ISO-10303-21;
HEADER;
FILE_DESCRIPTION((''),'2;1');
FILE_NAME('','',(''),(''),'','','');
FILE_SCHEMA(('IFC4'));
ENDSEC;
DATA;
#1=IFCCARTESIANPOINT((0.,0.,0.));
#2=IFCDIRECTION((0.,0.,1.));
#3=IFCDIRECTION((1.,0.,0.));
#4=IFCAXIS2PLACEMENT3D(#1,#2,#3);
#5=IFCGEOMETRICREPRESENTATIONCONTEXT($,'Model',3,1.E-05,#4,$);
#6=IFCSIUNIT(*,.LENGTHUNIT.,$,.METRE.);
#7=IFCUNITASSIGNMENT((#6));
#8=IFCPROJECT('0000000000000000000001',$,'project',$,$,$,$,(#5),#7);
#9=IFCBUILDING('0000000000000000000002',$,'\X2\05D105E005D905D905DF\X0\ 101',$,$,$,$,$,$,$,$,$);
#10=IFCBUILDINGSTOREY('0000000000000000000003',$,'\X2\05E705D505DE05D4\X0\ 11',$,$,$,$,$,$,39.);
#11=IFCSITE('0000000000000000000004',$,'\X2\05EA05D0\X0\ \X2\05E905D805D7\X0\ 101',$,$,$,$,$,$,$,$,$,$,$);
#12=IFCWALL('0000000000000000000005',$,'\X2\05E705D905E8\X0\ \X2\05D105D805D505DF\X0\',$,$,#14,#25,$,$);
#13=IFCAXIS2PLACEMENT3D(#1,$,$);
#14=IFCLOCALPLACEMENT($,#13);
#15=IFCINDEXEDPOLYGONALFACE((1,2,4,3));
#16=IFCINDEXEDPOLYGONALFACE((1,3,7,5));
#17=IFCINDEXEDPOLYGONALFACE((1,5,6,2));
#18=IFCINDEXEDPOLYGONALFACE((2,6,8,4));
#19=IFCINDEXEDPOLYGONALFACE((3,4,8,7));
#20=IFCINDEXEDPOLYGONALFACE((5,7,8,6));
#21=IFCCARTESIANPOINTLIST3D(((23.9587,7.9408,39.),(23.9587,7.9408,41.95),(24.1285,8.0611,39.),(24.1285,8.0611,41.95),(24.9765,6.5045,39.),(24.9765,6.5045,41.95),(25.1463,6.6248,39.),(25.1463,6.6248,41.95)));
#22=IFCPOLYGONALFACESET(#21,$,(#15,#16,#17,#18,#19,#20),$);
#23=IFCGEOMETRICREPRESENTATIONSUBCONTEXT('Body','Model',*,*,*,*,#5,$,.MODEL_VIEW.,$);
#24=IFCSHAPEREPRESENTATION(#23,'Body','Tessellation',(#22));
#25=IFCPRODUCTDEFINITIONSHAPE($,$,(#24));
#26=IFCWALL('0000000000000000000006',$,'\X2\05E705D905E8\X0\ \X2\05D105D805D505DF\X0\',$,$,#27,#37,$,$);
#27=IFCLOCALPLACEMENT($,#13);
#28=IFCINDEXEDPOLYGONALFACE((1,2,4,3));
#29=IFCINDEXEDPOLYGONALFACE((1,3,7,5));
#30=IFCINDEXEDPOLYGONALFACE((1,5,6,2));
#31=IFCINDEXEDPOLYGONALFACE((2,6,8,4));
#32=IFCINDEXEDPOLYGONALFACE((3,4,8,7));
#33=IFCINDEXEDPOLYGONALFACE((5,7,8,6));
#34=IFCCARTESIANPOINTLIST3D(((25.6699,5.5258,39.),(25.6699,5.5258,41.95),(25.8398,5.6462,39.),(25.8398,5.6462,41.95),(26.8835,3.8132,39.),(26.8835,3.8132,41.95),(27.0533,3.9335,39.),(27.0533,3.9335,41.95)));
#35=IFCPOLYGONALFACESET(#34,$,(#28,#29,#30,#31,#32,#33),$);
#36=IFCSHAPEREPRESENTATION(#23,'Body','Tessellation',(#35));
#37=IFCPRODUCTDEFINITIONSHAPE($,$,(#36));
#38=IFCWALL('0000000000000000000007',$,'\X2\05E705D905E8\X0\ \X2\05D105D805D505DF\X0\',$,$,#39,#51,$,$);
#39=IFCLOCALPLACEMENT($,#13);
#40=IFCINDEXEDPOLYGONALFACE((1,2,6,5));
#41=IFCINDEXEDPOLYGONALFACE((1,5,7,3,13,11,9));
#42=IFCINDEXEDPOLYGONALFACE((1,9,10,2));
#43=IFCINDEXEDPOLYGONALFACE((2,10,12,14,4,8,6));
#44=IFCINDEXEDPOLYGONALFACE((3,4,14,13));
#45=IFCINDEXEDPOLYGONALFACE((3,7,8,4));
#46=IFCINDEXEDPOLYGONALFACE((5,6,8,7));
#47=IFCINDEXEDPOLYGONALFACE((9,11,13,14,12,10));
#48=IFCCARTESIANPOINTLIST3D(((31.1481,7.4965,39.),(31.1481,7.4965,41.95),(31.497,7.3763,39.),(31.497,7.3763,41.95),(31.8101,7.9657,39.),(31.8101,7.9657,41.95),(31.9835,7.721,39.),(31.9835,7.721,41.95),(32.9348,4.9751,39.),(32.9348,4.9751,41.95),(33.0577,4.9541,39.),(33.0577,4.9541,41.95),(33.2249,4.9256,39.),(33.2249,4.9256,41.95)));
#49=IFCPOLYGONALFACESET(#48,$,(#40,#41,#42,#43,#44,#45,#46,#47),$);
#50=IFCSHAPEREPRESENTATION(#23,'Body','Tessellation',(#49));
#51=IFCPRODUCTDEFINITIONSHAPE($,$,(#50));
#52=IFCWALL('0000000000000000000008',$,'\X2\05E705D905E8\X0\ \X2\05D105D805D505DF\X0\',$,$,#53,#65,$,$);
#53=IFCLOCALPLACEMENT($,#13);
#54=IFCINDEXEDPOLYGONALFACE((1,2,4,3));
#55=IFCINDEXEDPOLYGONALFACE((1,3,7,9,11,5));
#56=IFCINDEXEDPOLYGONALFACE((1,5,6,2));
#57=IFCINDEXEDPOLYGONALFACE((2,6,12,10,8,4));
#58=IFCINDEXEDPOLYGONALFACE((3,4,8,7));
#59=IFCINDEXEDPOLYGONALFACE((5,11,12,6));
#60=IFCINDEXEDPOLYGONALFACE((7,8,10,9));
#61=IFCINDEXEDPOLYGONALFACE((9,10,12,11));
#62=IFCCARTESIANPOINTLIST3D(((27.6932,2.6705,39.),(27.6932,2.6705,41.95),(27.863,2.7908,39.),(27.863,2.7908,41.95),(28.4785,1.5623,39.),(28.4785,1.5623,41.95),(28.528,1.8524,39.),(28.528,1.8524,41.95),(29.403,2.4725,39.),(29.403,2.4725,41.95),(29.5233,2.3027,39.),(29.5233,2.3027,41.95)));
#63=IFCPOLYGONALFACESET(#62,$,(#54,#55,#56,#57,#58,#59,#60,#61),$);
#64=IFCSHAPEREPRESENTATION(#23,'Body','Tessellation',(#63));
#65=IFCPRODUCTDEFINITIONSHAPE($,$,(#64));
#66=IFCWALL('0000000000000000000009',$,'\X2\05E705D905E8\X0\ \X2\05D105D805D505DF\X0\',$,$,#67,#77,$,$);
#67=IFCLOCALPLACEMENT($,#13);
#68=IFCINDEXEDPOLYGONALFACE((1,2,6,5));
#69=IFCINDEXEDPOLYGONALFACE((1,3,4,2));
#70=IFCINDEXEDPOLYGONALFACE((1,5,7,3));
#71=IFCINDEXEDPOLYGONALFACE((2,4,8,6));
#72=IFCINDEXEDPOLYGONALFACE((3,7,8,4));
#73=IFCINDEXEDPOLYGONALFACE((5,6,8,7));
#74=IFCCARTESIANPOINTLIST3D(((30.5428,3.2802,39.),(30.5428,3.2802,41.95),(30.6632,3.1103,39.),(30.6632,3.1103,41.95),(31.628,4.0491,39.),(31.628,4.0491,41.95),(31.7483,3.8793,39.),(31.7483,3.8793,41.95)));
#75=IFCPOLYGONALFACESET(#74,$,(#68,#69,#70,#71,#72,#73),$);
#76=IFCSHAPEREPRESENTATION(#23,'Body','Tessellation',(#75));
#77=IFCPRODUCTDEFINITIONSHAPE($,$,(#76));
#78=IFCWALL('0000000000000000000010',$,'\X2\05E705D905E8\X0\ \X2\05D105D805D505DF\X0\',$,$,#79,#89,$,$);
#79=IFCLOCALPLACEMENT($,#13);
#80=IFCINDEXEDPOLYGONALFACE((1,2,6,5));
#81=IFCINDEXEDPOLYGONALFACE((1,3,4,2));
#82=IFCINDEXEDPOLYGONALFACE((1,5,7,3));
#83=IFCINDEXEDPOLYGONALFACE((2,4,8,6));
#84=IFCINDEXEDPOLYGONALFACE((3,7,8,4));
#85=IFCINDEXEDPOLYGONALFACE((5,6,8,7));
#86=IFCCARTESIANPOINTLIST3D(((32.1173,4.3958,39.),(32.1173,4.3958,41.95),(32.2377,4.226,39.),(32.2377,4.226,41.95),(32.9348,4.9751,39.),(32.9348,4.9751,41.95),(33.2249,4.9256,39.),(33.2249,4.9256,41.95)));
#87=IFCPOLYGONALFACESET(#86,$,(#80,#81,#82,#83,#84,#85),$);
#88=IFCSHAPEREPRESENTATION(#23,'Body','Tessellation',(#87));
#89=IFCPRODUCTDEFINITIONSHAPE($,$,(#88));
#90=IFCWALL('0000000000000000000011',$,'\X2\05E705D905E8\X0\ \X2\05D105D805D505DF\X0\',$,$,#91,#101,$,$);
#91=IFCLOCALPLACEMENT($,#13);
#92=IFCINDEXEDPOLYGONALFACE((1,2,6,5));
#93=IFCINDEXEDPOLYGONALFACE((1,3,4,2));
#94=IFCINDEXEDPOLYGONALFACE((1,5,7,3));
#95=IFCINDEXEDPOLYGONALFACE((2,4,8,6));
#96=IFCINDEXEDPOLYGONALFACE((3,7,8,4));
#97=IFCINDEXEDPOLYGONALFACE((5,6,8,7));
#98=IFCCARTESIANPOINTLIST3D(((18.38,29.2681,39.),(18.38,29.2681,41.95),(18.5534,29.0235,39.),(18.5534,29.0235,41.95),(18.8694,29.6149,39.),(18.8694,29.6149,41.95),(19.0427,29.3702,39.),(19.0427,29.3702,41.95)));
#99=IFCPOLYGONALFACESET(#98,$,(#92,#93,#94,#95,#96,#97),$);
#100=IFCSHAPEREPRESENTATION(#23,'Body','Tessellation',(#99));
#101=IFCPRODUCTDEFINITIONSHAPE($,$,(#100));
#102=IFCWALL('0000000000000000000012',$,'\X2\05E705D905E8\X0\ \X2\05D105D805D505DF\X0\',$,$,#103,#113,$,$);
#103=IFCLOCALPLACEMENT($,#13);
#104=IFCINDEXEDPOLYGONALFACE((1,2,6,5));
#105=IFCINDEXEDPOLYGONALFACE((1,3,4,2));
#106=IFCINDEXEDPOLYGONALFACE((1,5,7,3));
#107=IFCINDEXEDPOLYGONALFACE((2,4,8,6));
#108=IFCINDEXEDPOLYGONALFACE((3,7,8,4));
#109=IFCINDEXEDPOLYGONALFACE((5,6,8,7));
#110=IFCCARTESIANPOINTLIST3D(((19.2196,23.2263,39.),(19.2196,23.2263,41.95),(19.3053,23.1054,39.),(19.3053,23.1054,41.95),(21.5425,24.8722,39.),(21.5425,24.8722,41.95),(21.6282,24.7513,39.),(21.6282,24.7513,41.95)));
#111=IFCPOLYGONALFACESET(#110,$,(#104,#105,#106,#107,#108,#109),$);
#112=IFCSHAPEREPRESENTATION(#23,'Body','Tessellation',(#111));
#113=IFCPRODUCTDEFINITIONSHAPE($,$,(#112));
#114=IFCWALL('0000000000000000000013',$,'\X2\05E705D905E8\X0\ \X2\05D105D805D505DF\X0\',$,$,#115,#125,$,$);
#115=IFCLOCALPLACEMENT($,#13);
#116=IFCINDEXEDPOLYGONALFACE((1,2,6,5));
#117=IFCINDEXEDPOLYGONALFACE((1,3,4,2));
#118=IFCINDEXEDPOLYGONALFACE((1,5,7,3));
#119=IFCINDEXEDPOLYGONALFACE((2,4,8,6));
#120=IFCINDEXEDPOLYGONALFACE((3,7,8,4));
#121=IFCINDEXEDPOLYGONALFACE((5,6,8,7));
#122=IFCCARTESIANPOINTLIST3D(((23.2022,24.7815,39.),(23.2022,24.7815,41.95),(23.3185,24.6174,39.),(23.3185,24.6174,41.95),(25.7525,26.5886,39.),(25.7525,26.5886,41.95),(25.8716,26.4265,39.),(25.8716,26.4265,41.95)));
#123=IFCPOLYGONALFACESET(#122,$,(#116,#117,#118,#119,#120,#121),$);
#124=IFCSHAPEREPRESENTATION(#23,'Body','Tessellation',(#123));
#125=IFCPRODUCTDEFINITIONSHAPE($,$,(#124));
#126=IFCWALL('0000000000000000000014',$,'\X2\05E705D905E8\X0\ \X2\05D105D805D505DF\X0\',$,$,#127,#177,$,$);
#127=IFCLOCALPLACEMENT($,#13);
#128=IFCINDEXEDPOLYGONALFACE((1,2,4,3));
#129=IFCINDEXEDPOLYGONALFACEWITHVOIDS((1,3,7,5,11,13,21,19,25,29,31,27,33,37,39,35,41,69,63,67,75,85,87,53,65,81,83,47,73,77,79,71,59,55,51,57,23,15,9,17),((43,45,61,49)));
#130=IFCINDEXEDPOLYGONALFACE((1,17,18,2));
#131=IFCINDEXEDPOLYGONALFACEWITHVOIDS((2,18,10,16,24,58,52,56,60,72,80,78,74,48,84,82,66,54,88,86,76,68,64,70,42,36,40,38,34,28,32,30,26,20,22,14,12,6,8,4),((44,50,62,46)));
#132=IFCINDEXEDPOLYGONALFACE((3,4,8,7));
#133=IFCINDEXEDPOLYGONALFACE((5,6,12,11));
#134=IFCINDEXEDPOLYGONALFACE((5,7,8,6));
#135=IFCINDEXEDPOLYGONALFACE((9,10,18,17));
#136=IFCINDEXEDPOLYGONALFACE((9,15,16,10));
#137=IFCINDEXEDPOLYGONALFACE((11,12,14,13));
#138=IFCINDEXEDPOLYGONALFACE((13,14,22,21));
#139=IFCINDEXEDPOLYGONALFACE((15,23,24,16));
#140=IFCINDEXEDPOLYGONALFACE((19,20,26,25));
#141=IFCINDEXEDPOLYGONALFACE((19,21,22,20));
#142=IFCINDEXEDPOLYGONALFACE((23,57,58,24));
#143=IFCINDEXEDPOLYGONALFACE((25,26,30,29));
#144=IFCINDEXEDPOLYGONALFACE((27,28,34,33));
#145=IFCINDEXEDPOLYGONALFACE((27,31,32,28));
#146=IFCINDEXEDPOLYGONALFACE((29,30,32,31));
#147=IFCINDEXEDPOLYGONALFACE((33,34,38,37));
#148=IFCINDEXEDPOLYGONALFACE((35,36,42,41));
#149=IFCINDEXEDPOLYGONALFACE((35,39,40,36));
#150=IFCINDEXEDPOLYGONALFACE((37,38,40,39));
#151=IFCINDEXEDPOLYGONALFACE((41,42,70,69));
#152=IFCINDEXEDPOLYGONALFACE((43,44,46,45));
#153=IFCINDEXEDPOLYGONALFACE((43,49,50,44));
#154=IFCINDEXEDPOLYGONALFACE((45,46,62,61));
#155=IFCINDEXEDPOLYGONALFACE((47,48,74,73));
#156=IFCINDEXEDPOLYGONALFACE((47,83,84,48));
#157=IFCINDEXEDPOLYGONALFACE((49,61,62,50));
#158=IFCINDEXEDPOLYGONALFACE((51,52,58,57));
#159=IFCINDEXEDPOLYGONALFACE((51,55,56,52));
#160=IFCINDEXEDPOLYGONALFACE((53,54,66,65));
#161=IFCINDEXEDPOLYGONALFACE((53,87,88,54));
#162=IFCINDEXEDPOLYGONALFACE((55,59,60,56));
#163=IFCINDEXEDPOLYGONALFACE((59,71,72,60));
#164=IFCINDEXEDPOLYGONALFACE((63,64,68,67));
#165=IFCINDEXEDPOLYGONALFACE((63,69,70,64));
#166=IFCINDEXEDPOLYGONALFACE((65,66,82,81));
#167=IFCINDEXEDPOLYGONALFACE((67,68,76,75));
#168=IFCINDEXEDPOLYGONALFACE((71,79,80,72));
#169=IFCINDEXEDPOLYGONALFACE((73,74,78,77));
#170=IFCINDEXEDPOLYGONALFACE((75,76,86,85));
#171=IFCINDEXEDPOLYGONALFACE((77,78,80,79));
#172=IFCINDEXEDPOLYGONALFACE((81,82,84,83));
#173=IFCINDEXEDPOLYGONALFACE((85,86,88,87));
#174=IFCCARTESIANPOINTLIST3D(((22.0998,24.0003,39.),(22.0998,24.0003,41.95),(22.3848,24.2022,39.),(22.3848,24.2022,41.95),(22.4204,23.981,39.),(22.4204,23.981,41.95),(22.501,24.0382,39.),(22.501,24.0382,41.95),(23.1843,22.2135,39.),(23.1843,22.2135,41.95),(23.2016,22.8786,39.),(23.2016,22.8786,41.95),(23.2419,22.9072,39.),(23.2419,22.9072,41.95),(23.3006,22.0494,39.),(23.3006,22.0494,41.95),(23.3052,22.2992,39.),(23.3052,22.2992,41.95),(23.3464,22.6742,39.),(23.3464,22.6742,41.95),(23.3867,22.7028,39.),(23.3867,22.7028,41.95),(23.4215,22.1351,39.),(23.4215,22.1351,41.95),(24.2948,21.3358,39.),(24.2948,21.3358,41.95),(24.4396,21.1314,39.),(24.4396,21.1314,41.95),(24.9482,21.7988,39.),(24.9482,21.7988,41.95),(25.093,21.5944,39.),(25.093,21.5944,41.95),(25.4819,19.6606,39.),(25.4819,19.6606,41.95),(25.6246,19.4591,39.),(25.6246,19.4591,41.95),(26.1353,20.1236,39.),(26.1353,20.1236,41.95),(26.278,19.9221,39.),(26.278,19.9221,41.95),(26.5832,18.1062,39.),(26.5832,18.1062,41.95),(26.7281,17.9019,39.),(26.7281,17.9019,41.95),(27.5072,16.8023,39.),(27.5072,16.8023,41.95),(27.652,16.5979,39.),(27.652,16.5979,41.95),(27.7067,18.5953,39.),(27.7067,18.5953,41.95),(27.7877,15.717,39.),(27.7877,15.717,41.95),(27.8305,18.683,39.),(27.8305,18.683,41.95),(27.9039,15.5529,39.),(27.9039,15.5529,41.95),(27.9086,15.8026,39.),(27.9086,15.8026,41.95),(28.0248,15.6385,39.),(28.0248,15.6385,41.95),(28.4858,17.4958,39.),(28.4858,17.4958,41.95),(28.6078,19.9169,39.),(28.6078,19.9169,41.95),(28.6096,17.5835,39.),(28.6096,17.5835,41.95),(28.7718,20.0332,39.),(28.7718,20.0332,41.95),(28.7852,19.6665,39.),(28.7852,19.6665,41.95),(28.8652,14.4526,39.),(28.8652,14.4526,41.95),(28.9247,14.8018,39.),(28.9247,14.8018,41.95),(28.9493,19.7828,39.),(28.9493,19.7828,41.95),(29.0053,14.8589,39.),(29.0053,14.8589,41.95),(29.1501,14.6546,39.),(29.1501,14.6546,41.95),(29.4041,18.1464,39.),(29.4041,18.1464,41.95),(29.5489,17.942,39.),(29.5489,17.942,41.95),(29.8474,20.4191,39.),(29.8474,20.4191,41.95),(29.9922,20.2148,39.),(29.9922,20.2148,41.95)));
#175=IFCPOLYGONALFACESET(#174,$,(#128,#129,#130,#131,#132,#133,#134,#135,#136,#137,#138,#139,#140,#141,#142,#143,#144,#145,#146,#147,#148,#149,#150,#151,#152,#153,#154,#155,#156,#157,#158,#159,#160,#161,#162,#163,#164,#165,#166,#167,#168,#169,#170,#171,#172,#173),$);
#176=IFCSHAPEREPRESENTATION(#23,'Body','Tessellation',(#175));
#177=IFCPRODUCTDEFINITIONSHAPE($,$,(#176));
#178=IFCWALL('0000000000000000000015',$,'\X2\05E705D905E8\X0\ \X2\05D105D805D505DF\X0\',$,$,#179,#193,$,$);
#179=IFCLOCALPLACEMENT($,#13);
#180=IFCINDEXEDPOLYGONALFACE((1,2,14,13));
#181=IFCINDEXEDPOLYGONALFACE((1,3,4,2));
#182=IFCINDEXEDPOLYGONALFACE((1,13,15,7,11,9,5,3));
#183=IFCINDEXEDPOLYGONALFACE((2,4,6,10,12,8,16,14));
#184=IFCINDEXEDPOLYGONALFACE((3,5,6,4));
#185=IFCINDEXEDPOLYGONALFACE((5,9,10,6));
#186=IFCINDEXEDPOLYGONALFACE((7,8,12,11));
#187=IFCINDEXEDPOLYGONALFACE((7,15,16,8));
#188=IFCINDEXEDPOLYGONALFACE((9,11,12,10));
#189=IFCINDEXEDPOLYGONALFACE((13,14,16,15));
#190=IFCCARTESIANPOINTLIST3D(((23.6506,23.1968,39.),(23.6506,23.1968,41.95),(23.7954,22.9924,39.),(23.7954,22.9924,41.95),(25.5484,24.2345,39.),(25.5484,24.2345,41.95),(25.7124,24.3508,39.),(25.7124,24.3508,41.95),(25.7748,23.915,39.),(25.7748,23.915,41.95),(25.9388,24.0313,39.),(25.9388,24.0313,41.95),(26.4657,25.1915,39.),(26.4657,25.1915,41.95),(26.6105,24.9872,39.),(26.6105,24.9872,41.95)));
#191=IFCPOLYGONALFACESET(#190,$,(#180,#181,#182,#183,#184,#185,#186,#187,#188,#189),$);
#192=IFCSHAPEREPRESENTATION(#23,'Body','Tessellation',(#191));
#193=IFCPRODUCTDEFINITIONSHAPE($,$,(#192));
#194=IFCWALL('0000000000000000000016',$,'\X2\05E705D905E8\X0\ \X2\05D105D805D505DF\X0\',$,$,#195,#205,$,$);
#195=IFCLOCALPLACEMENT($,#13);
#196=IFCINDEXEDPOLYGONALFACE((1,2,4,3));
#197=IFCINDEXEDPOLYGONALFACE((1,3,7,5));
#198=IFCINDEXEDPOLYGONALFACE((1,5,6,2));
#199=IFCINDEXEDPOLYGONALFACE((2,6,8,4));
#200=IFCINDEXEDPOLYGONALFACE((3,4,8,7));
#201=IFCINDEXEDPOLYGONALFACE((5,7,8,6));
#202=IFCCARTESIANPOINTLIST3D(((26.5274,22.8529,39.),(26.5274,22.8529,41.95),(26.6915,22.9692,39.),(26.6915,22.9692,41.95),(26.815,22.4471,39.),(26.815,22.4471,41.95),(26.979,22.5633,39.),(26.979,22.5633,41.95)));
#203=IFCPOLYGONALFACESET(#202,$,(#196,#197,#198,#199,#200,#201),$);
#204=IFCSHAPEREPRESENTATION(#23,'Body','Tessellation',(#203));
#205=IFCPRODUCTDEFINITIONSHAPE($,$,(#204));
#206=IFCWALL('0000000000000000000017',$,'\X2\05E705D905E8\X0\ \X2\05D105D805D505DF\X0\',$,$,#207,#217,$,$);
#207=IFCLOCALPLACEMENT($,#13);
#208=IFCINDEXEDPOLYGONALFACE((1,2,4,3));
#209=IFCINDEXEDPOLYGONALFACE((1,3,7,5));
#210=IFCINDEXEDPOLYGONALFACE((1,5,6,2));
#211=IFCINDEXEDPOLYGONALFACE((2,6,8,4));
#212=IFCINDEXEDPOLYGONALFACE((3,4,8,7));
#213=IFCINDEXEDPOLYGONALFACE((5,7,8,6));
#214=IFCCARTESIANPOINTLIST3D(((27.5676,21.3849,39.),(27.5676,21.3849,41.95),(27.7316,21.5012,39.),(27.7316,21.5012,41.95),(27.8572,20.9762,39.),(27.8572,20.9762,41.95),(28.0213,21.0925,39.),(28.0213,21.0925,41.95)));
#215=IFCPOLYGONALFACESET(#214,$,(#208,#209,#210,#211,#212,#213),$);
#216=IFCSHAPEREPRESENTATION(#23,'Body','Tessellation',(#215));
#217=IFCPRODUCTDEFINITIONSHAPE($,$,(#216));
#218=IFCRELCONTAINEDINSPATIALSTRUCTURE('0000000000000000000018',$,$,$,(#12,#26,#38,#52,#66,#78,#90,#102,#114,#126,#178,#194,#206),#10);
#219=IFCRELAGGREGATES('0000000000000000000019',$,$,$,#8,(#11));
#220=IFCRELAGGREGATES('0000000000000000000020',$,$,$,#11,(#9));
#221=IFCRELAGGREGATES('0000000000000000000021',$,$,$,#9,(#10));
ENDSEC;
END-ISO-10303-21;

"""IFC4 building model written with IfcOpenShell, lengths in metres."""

from ifc_helpers import new_model, si_unit, frame, origin_with_axes, context, subcontext, project, spatial, polyline, outline, extrude, element, save


model = new_model("IFC4")

# Units and contexts
model_context = context("Model", 3, precision=1e-05, world=origin_with_axes())
body_context = subcontext(model_context, "Body", "Model", "MODEL_VIEW")
ifc_project = project(units=[si_unit("LENGTHUNIT", "METRE")], contexts=[model_context])

# Site, building, storey
site = spatial("IfcSite", under=ifc_project, Name="תא שטח 101")
building = spatial("IfcBuilding", under=site, Name="בניין 101")
storey = spatial("IfcBuildingStorey", under=building, Name="קומה 11", Elevation=39.0)

# Walls
element("IfcWall", 1, inside=storey, Name="קיר בטון", context=body_context, shape_type="SweptSolid", body=[
    extrude(outline(polyline([(23.9587, 7.9408), (24.9765, 6.5045), (25.1463, 6.6248), (24.1285, 8.0611), (23.9587, 7.9408)])), frame((0.0, 0.0, 39.0)), (0.0, 0.0, 1.0), 2.95),
])
element("IfcWall", 2, inside=storey, Name="קיר בטון", context=body_context, shape_type="SweptSolid", body=[
    extrude(outline(polyline([(25.8398, 5.6462), (25.6699, 5.5258), (26.8835, 3.8132), (27.0533, 3.9335), (25.8398, 5.6462)])), frame((0.0, 0.0, 39.0)), (0.0, 0.0, 1.0), 2.95),
])
element("IfcWall", 3, inside=storey, Name="קיר בטון", context=body_context, shape_type="SweptSolid", body=[
    extrude(outline(polyline([(31.497, 7.3763), (31.9835, 7.721), (31.8101, 7.9657), (31.1481, 7.4965), (32.9348, 4.9751), (33.0577, 4.9541), (33.2249, 4.9256), (31.497, 7.3763)])), frame((0.0, 0.0, 39.0)), (0.0, 0.0, 1.0), 2.95),
])
element("IfcWall", 4, inside=storey, Name="קיר בטון", context=body_context, shape_type="SweptSolid", body=[
    extrude(outline(polyline([(28.4785, 1.5623), (29.5233, 2.3027), (29.403, 2.4725), (28.528, 1.8524), (27.863, 2.7908), (27.6932, 2.6705), (28.4785, 1.5623)])), frame((0.0, 0.0, 39.0)), (0.0, 0.0, 1.0), 2.95),
])
element("IfcWall", 5, inside=storey, Name="קיר בטון", context=body_context, shape_type="SweptSolid", body=[
    extrude(outline(polyline([(31.628, 4.0491), (30.5428, 3.2802), (30.6632, 3.1103), (31.7483, 3.8793), (31.628, 4.0491)])), frame((0.0, 0.0, 39.0)), (0.0, 0.0, 1.0), 2.95),
])
element("IfcWall", 6, inside=storey, Name="קיר בטון", context=body_context, shape_type="SweptSolid", body=[
    extrude(outline(polyline([(32.1173, 4.3958), (32.2377, 4.226), (33.2249, 4.9256), (32.9348, 4.9751), (32.1173, 4.3958)])), frame((0.0, 0.0, 39.0)), (0.0, 0.0, 1.0), 2.95),
])
element("IfcWall", 7, inside=storey, Name="קיר בטון", context=body_context, shape_type="SweptSolid", body=[
    extrude(outline(polyline([(18.38, 29.2681), (18.5534, 29.0235), (19.0427, 29.3702), (18.8694, 29.6149), (18.38, 29.2681)])), frame((0.0, 0.0, 39.0)), (0.0, 0.0, 1.0), 2.95),
])
element("IfcWall", 8, inside=storey, Name="קיר בטון", context=body_context, shape_type="SweptSolid", body=[
    extrude(outline(polyline([(21.6282, 24.7513), (21.5425, 24.8722), (19.2196, 23.2263), (19.3053, 23.1054), (21.6282, 24.7513)])), frame((0.0, 0.0, 39.0)), (0.0, 0.0, 1.0), 2.95),
])
element("IfcWall", 9, inside=storey, Name="קיר בטון", context=body_context, shape_type="SweptSolid", body=[
    extrude(outline(polyline([(23.2022, 24.7815), (23.3185, 24.6174), (25.8716, 26.4265), (25.7525, 26.5886), (23.2022, 24.7815)])), frame((0.0, 0.0, 39.0)), (0.0, 0.0, 1.0), 2.95),
])
element("IfcWall", 10, inside=storey, Name="קיר בטון", context=body_context, shape_type="SweptSolid", body=[
    extrude(outline(polyline([(23.1843, 22.2135), (23.3006, 22.0494), (23.4215, 22.1351), (27.9086, 15.8026), (27.7877, 15.717), (27.9039, 15.5529), (28.0248, 15.6385), (28.8652, 14.4526), (29.1501, 14.6546), (29.0053, 14.8589), (28.9247, 14.8018), (27.652, 16.5979), (29.5489, 17.942), (29.4041, 18.1464), (28.6096, 17.5835), (27.8305, 18.683), (29.9922, 20.2148), (29.8474, 20.4191), (28.9493, 19.7828), (28.7718, 20.0332), (28.6078, 19.9169), (28.7852, 19.6665), (26.5832, 18.1062), (25.6246, 19.4591), (26.278, 19.9221), (26.1353, 20.1236), (25.4819, 19.6606), (24.4396, 21.1314), (25.093, 21.5944), (24.9482, 21.7988), (24.2948, 21.3358), (23.3464, 22.6742), (23.3867, 22.7028), (23.2419, 22.9072), (23.2016, 22.8786), (22.4204, 23.981), (22.501, 24.0382), (22.3848, 24.2022), (22.0998, 24.0003), (23.3052, 22.2992), (23.1843, 22.2135)]), holes=[polyline([(26.7281, 17.9019), (27.7067, 18.5953), (28.4858, 17.4958), (27.5072, 16.8023), (26.7281, 17.9019)])]), frame((0.0, 0.0, 39.0)), (0.0, 0.0, 1.0), 2.95),
])
element("IfcWall", 11, inside=storey, Name="קיר בטון", context=body_context, shape_type="SweptSolid", body=[
    extrude(outline(polyline([(25.7124, 24.3508), (26.6105, 24.9872), (26.4657, 25.1915), (23.6506, 23.1968), (23.7954, 22.9924), (25.5484, 24.2345), (25.7748, 23.915), (25.9388, 24.0313), (25.7124, 24.3508)])), frame((0.0, 0.0, 39.0)), (0.0, 0.0, 1.0), 2.95),
])
element("IfcWall", 12, inside=storey, Name="קיר בטון", context=body_context, shape_type="SweptSolid", body=[
    extrude(outline(polyline([(26.815, 22.4471), (26.979, 22.5633), (26.6915, 22.9692), (26.5274, 22.8529), (26.815, 22.4471)])), frame((0.0, 0.0, 39.0)), (0.0, 0.0, 1.0), 2.95),
])
element("IfcWall", 13, inside=storey, Name="קיר בטון", context=body_context, shape_type="SweptSolid", body=[
    extrude(outline(polyline([(28.0213, 21.0925), (27.7316, 21.5012), (27.5676, 21.3849), (27.8572, 20.9762), (28.0213, 21.0925)])), frame((0.0, 0.0, 39.0)), (0.0, 0.0, 1.0), 2.95),
])

save(model, "model.ifc")
